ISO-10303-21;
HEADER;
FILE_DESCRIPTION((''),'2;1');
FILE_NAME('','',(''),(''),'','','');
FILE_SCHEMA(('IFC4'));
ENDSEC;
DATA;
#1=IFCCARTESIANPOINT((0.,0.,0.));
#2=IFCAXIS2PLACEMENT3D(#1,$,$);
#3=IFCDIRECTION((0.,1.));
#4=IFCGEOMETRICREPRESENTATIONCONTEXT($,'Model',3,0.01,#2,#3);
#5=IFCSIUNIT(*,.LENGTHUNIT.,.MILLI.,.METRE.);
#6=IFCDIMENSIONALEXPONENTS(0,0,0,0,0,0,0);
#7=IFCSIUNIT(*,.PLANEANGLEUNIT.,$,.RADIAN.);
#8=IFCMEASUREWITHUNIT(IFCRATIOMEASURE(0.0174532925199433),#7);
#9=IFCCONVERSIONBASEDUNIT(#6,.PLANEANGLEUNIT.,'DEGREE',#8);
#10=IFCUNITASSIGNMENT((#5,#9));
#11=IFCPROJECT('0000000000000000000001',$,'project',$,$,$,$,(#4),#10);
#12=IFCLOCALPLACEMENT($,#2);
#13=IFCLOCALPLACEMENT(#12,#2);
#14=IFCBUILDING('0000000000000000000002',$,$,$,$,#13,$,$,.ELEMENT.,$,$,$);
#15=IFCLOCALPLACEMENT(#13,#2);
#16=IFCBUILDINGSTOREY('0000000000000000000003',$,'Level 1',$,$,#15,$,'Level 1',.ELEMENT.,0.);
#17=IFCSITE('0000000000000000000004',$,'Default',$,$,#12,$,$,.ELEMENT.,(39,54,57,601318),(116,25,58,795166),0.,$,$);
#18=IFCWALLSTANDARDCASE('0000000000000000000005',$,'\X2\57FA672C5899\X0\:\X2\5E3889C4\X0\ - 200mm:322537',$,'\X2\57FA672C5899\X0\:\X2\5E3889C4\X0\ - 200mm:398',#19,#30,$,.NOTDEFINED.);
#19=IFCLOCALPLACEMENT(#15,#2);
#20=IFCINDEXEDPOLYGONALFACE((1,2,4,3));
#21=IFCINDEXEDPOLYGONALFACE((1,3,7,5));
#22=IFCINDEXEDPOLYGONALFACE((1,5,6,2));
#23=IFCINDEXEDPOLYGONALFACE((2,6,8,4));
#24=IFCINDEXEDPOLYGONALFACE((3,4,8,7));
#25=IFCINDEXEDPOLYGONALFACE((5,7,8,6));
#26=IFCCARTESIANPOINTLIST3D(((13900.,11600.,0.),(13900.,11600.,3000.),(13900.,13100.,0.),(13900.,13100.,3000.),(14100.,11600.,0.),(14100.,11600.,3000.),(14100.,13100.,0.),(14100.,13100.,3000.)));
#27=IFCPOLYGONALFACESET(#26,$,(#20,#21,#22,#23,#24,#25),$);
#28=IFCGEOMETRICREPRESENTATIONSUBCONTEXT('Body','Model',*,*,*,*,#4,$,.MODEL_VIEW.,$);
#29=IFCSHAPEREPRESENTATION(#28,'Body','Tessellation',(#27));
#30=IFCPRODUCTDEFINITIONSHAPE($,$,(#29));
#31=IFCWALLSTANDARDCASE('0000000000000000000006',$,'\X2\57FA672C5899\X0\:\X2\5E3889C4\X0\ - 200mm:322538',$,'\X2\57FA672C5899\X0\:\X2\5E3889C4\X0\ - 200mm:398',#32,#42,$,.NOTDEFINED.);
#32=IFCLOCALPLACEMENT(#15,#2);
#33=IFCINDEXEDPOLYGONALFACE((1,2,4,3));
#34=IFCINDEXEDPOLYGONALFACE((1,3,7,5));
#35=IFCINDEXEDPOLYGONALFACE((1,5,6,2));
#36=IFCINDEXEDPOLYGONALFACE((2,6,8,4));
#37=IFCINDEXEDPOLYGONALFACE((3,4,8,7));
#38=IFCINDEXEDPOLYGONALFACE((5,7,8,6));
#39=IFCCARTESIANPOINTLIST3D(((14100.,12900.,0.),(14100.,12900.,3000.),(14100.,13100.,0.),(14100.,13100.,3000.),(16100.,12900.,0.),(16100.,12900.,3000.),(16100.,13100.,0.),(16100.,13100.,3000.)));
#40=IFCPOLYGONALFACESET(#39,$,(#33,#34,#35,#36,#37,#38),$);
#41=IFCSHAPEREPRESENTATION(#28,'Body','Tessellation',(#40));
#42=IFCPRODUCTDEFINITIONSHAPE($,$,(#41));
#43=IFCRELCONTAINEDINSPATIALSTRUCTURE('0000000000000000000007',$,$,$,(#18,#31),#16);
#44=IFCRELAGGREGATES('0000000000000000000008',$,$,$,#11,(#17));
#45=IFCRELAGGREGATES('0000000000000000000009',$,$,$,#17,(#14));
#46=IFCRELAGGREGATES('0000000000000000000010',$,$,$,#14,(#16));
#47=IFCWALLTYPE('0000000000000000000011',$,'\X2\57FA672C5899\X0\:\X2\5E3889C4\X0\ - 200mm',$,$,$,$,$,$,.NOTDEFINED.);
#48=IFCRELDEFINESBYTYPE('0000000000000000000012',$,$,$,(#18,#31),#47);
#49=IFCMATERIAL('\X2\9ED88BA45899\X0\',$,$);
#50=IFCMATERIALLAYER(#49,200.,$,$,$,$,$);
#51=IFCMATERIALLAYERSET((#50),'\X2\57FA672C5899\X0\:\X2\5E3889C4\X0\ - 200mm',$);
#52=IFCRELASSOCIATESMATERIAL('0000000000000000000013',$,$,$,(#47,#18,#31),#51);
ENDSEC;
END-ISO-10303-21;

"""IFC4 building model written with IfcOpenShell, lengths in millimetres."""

from ifc_helpers import new_model, entity, si_unit, converted_unit, direction, frame, frame_2d, origin, place, context, subcontext, project, spatial, rectangle, extrude, material, layer, layer_set, layer_usage, type_object, element, save


model = new_model("IFC4")

# Units and contexts
model_context_1 = context("Model", 3, precision=0.01, world=origin(), true_north=direction((0.0, 1.0)))
body_context_1 = subcontext(model_context_1, "Body", "Model", "MODEL_VIEW")
ifc_project = project(units=[si_unit("LENGTHUNIT", "METRE", prefix="MILLI"), converted_unit("PLANEANGLEUNIT", "DEGREE", entity("IfcRatioMeasure", 0.0174532925199433), si_unit("PLANEANGLEUNIT", "RADIAN"), dimensions=[0, 0, 0, 0, 0, 0, 0])], contexts=[model_context_1])

# Site, building, storey
site_placement = place(None, origin())
site = spatial("IfcSite", under=ifc_project, at=site_placement, Name="Default", CompositionType="ELEMENT", RefLatitude=(39, 54, 57, 601318), RefLongitude=(116, 25, 58, 795166), RefElevation=0.0)
building_placement = place(site_placement, origin())
building = spatial("IfcBuilding", under=site, at=building_placement, CompositionType="ELEMENT")
storey_placement = place(building_placement, origin())
storey = spatial("IfcBuildingStorey", under=building, at=storey_placement, Name="Level 1", LongName="Level 1", CompositionType="ELEMENT", Elevation=0.0)

# Shared definitions
ifc_material_1 = material(Name="默认墙")
ifc_layer = layer(ifc_material_1, 200.0)
ifc_layer_set = layer_set([ifc_layer], Name="基本墙:常规 - 200mm")
wall_type = type_object("IfcWallType", Name="基本墙:常规 - 200mm", PredefinedType="NOTDEFINED", material=ifc_layer_set)

# Walls
ifc_layer_usage_1 = layer_usage(ifc_layer_set, "AXIS2", "NEGATIVE", 100.0)
wall_1_placement = place(storey_placement, frame((14000.0, 11600.0, 0.0), z_axis=(0.0, 0.0, 1.0), x_axis=(0.0, 1.0, 0.0)))
element("IfcWallStandardCase", 1, at=wall_1_placement, inside=storey, type_object=wall_type, material=ifc_layer_usage_1, Name="基本墙:常规 - 200mm:322537", ObjectType="基本墙:常规 - 200mm:398", PredefinedType="NOTDEFINED", context=body_context_1, shape_type="SweptSolid", body=[
    extrude(rectangle(XDim=1500.0, YDim=200.0, at=frame_2d((750.0, 0.0), x_axis=(-1.0, 0.0))), origin(), (0.0, 0.0, 1.0), 3000.0),
])
ifc_layer_usage_2 = layer_usage(ifc_layer_set, "AXIS2", "NEGATIVE", 100.0)
wall_2_placement = place(storey_placement, frame((14100.0, 13000.0, 0.0)))
element("IfcWallStandardCase", 2, at=wall_2_placement, inside=storey, type_object=wall_type, material=ifc_layer_usage_2, Name="基本墙:常规 - 200mm:322538", ObjectType="基本墙:常规 - 200mm:398", PredefinedType="NOTDEFINED", context=body_context_1, shape_type="SweptSolid", body=[
    extrude(rectangle(XDim=2000.0, YDim=200.0, at=frame_2d((1000.0, 0.0), x_axis=(-1.0, 0.0))), origin(), (0.0, 0.0, 1.0), 3000.0),
])

save(model, "model.ifc")
